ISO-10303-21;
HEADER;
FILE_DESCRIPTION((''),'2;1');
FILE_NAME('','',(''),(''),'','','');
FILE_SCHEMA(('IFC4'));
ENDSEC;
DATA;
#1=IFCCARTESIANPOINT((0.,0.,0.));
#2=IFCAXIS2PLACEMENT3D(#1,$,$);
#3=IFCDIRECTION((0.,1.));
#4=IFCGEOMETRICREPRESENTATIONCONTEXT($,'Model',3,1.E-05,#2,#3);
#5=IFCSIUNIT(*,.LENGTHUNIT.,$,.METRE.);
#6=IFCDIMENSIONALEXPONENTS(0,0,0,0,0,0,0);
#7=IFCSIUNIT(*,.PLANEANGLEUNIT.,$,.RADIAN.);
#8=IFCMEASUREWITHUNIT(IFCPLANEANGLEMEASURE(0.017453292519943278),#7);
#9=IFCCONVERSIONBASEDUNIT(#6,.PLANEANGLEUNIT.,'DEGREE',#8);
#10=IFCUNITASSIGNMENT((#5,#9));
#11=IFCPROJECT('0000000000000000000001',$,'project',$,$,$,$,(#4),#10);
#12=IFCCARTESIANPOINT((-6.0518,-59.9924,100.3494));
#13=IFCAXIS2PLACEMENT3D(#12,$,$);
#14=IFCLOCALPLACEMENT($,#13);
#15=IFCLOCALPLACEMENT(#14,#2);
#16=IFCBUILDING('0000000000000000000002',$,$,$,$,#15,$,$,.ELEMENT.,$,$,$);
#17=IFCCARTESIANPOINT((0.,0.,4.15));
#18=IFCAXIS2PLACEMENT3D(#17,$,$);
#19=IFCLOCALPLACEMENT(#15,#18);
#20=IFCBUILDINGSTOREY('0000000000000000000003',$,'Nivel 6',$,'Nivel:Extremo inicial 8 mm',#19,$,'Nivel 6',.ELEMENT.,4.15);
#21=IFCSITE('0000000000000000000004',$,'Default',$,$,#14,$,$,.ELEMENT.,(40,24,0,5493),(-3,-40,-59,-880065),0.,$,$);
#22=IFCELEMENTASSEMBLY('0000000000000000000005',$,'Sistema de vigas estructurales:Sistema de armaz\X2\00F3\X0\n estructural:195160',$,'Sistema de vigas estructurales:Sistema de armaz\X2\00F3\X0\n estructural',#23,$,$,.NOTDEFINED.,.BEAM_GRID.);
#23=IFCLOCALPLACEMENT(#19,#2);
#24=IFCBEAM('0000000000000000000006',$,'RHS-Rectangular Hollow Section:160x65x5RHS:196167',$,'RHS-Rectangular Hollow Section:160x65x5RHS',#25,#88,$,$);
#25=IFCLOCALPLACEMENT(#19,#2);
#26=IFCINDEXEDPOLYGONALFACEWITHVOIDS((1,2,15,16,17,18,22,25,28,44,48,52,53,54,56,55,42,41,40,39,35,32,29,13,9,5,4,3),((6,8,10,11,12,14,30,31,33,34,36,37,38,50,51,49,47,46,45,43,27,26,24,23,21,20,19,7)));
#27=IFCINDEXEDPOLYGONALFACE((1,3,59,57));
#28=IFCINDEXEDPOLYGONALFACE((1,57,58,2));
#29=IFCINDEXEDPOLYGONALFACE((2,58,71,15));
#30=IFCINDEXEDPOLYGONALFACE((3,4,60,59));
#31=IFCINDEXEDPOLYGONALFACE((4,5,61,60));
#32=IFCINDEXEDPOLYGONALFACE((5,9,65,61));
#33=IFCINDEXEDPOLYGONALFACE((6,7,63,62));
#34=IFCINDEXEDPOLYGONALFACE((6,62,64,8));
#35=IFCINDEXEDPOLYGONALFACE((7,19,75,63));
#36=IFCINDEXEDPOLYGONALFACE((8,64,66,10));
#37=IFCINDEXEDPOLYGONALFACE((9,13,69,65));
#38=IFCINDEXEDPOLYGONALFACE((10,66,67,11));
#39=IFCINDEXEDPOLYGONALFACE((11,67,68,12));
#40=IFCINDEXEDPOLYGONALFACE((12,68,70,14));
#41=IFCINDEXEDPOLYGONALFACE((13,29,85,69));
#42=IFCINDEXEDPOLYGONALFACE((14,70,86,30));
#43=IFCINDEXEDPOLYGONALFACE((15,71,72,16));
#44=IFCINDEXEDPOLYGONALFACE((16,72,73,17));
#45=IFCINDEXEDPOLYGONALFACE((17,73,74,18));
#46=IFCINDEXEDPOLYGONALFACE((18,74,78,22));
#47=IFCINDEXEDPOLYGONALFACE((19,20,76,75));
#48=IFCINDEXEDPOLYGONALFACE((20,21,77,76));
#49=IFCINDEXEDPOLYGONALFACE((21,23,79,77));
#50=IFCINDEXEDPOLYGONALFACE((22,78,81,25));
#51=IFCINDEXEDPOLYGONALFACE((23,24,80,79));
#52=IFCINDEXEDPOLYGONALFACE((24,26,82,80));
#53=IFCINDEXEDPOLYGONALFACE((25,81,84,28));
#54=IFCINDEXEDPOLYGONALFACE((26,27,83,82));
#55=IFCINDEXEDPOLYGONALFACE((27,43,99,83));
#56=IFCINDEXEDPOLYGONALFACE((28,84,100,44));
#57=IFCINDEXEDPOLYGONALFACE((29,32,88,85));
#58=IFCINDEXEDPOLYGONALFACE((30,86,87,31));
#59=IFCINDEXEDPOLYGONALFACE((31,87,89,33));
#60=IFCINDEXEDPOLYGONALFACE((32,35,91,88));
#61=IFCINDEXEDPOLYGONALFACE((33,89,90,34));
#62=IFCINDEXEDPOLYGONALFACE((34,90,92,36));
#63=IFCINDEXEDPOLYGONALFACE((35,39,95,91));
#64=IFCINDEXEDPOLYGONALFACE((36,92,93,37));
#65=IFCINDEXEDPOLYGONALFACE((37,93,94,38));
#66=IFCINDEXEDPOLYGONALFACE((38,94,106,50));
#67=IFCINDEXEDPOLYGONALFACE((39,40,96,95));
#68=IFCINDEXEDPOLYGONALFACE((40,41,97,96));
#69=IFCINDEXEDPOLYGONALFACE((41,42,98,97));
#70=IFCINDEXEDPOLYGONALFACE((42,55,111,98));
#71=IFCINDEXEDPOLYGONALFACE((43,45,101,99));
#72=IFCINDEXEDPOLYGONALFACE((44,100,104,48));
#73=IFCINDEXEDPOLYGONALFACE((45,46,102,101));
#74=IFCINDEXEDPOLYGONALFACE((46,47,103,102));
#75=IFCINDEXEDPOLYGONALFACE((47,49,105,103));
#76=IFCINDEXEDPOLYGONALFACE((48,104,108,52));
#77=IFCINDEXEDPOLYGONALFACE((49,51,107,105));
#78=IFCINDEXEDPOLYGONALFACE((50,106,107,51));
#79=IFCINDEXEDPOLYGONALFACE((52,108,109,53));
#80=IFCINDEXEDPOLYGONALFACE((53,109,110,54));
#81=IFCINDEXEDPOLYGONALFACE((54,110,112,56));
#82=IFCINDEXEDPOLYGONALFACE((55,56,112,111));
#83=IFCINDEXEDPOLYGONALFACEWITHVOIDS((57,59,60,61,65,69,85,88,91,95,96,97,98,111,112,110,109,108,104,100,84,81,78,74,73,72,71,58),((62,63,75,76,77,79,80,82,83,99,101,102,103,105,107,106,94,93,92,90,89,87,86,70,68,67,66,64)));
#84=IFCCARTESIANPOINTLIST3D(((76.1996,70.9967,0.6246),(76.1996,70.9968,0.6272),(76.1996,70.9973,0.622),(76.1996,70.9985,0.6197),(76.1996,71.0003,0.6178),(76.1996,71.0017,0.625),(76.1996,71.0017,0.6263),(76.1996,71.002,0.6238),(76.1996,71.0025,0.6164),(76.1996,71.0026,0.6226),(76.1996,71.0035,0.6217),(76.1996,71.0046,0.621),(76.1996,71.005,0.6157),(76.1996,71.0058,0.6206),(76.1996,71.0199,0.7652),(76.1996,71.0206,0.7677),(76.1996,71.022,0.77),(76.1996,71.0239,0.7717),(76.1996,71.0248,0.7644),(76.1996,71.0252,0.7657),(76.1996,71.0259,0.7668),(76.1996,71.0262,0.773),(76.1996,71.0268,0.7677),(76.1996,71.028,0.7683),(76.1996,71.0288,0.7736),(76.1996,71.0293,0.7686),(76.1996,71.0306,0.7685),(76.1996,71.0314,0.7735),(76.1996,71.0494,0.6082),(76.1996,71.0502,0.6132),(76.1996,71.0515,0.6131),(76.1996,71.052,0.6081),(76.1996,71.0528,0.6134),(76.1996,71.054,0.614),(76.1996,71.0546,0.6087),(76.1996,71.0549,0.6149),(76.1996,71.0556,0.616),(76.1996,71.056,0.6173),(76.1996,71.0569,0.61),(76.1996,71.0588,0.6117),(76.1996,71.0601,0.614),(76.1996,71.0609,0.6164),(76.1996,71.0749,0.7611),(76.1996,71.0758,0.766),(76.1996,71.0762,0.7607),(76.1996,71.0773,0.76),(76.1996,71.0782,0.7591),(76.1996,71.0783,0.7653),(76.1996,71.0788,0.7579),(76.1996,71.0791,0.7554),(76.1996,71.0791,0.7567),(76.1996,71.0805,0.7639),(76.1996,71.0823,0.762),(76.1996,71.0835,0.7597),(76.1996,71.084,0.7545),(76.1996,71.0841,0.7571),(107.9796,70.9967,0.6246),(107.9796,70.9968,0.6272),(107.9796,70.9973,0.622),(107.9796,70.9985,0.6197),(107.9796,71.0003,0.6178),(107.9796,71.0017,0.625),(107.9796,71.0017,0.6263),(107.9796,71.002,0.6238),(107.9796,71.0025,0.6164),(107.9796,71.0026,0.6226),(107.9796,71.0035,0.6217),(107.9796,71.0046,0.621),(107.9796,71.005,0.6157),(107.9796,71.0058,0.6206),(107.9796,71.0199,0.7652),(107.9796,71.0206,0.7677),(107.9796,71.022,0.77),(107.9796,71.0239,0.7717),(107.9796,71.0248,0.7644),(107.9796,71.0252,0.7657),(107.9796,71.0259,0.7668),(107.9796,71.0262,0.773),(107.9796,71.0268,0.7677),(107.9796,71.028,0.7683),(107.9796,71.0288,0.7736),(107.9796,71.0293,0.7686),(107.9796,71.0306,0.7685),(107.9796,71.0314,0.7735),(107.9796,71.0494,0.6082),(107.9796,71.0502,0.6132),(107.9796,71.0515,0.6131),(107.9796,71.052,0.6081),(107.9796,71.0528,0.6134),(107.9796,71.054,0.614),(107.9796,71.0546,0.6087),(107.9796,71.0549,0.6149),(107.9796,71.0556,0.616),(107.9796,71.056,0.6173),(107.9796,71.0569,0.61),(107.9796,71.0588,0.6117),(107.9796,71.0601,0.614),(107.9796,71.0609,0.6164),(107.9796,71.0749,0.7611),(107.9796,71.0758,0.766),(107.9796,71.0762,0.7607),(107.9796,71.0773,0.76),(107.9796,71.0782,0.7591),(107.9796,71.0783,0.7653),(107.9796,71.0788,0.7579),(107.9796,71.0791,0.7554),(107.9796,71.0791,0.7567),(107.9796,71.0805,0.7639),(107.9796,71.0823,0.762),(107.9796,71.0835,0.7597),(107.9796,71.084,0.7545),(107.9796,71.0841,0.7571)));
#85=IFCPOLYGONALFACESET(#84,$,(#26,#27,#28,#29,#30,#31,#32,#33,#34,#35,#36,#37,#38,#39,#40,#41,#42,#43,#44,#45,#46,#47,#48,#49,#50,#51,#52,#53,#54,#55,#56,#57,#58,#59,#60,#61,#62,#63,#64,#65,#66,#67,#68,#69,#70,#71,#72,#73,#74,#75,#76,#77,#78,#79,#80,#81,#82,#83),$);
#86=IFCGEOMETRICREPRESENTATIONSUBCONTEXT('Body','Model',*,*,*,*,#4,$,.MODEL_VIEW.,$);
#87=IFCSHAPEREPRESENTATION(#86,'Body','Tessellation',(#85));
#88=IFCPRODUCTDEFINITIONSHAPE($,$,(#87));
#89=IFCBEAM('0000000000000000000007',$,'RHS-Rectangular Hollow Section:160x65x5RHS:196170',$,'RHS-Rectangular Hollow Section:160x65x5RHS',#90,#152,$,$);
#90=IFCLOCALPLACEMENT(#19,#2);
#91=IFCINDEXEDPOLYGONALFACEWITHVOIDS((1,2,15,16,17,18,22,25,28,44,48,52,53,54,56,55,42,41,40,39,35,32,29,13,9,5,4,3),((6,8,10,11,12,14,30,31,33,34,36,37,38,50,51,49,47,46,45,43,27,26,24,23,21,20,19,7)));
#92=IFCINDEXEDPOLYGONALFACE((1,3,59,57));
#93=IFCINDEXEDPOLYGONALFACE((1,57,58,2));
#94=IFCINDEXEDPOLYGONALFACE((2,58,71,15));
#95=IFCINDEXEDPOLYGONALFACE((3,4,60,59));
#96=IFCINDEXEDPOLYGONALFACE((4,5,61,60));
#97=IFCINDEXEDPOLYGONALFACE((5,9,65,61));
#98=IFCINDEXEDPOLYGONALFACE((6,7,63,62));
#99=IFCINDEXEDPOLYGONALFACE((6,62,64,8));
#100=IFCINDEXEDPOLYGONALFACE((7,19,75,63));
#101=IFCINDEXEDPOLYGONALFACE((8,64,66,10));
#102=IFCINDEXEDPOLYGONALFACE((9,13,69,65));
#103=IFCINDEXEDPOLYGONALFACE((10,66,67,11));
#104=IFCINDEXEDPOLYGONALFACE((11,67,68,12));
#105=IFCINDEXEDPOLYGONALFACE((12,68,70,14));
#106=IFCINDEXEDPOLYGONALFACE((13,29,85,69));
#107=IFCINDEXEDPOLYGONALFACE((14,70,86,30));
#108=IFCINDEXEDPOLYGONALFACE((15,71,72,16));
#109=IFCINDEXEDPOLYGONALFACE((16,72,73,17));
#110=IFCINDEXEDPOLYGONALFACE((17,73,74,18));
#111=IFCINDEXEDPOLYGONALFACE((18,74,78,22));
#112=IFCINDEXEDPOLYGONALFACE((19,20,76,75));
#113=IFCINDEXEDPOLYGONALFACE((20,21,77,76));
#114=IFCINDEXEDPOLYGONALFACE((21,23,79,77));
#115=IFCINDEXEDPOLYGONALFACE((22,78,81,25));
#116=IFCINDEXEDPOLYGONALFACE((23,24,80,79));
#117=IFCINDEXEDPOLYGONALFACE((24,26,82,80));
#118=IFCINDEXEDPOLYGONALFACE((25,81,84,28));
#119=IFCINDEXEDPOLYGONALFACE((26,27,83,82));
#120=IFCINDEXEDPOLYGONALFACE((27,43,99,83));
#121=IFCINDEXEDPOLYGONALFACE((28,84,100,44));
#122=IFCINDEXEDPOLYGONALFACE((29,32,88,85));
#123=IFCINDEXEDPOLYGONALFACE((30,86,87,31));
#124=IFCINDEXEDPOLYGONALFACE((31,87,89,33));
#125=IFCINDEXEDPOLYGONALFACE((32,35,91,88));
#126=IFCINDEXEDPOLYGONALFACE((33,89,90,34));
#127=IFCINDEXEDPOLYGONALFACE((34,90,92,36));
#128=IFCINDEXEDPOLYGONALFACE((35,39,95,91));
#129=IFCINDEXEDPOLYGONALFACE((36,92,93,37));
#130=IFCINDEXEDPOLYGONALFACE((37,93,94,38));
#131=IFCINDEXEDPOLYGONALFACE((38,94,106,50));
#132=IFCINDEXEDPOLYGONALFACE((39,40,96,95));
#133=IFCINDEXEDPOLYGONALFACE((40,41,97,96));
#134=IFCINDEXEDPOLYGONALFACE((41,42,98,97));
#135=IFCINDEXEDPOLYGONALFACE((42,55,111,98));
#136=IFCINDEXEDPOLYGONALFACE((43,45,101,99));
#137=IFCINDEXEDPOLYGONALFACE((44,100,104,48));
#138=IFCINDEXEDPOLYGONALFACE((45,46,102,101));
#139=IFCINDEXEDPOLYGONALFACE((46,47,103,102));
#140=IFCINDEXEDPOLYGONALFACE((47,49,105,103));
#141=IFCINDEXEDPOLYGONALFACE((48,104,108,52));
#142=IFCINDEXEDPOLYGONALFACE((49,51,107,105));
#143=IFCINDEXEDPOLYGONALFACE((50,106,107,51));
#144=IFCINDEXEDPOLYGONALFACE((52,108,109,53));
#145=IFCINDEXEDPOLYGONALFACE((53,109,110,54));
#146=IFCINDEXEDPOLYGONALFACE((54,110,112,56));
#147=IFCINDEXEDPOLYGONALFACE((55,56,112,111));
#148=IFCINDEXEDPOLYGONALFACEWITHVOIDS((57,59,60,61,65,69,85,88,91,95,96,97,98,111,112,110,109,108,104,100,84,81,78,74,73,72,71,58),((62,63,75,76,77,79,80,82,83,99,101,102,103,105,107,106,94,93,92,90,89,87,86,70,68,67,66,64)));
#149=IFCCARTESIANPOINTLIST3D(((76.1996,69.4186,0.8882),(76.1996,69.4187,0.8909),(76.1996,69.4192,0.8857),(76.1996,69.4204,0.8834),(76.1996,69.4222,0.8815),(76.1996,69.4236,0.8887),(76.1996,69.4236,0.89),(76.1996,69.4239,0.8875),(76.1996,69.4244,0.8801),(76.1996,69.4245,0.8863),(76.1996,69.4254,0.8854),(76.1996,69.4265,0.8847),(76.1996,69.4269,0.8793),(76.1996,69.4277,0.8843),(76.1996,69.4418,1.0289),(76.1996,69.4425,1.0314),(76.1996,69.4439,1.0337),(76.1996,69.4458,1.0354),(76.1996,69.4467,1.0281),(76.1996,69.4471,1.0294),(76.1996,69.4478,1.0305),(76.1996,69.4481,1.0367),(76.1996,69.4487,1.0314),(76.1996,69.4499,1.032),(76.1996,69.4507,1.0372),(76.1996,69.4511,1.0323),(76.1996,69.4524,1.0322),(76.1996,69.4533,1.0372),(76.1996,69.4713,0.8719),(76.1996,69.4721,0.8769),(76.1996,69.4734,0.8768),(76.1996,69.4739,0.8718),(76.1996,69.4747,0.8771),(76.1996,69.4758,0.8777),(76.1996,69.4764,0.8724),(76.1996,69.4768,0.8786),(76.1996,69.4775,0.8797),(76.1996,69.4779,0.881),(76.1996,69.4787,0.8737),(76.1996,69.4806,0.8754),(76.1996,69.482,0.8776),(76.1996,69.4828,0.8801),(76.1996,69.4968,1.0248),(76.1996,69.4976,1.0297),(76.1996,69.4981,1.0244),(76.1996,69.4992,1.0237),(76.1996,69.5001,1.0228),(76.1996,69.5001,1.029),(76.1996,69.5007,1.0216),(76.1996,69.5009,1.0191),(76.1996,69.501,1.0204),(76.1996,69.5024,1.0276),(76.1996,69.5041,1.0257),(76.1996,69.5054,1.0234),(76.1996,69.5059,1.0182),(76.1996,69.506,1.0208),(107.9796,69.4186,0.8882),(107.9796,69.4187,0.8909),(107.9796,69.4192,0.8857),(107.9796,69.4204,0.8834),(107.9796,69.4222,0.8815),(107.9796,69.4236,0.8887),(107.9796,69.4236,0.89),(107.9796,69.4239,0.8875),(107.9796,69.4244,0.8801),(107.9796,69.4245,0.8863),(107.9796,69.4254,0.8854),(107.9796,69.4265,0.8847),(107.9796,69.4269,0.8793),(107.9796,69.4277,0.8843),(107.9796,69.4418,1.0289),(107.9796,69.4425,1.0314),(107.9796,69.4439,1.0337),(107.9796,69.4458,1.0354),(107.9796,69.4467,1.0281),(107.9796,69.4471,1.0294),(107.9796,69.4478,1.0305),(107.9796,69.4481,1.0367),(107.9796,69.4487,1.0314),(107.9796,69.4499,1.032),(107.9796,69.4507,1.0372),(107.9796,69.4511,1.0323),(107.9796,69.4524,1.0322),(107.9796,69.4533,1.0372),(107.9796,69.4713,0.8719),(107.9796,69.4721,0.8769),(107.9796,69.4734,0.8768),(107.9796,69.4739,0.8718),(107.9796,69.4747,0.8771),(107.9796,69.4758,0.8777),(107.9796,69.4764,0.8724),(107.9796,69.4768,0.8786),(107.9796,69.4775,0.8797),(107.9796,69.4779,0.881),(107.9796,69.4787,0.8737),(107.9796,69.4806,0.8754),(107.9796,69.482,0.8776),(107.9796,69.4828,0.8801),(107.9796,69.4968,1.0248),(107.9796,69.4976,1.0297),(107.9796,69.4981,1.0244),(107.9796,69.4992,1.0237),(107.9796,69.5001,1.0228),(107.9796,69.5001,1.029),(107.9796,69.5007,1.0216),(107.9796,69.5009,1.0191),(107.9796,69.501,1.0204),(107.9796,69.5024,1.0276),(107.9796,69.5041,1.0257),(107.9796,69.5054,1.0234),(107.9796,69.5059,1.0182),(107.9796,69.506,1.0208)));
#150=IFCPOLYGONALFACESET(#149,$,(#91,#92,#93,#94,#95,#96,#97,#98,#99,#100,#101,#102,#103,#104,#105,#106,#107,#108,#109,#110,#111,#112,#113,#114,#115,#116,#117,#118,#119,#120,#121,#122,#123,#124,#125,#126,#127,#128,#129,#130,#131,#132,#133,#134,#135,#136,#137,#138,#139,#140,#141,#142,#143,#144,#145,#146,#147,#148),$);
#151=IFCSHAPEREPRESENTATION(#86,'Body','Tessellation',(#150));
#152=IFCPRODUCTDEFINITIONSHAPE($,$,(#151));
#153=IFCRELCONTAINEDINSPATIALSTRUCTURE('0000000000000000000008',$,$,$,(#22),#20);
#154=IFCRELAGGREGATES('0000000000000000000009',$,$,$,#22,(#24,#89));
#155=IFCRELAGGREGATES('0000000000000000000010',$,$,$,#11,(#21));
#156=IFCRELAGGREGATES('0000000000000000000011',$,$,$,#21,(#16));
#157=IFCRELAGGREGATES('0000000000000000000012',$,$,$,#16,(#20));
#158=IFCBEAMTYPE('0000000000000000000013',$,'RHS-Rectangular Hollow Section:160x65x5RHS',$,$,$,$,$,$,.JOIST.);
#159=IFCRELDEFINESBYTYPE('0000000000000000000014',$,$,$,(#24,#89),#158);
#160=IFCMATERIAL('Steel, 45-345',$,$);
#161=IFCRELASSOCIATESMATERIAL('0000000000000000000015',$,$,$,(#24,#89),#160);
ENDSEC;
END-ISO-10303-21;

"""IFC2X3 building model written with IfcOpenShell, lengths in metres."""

from ifc_helpers import new_model, entity, si_unit, converted_unit, direction, frame, frame_2d, origin, place, context, subcontext, project, spatial, polyline, circle_curve, parameter, trimmed, segment, composite_curve, outline, extrude, material, type_object, element, aggregate, save


model = new_model("IFC2X3")

# Units and contexts
model_context = context("Model", 3, precision=1e-05, world=origin(), true_north=direction((0.0, 1.0)))
body_context = subcontext(model_context, "Body", "Model", "MODEL_VIEW")
ifc_project = project(units=[si_unit("LENGTHUNIT", "METRE"), converted_unit("PLANEANGLEUNIT", "DEGREE", entity("IfcPlaneAngleMeasure", 0.017453292519943278), si_unit("PLANEANGLEUNIT", "RADIAN"), dimensions=[0, 0, 0, 0, 0, 0, 0])], contexts=[model_context])

# Site, building, storey
site_placement = place(None, frame((-6.0518, -59.9924, 100.3494)))
site = spatial("IfcSite", under=ifc_project, at=site_placement, Name="Default", CompositionType="ELEMENT", RefLatitude=(40, 24, 0, 5493), RefLongitude=(-3, -40, -59, -880065), RefElevation=0.0)
building_placement = place(site_placement, origin())
building = spatial("IfcBuilding", under=site, at=building_placement, CompositionType="ELEMENT")
storey_placement = place(building_placement, frame((0.0, 0.0, 4.15)))
storey = spatial("IfcBuildingStorey", under=building, at=storey_placement, Name="Nivel 6", ObjectType="Nivel:Extremo inicial 8 mm", LongName="Nivel 6", CompositionType="ELEMENT", Elevation=4.15)

# Shared definitions
ifc_material_1 = material(Name="Steel, 45-345")

# Element assembly, beams
assembly_placement = place(storey_placement, origin())
assembly = element("IfcElementAssembly", 1, at=assembly_placement, inside=storey, Name="Sistema de vigas estructurales:Sistema de armazón estructural:195160", ObjectType="Sistema de vigas estructurales:Sistema de armazón estructural", AssemblyPlace="NOTDEFINED", PredefinedType="BEAM_GRID")
beam_type_1 = type_object("IfcBeamType", Name="RHS-Rectangular Hollow Section:160x65x5RHS", PredefinedType="JOIST")
beam_1_placement = place(assembly_placement, frame((107.9796, 71.0008, 0.4541), z_axis=(0.0, 0.0, 1.0), x_axis=(-1.0, 0.0, 0.0)))
beam_1 = element("IfcBeam", 2, at=beam_1_placement, type_object=beam_type_1, material=ifc_material_1, Name="RHS-Rectangular Hollow Section:160x65x5RHS:196167", ObjectType="RHS-Rectangular Hollow Section:160x65x5RHS", context=body_context, shape_type="SweptSolid", body=[
    extrude(outline(composite_curve([segment(trimmed(circle_curve(frame_2d((-0.0225, -0.07), x_axis=(1.0, 0.0)), 0.01), [parameter(180.0)], [parameter(270.0)], True, "PARAMETER"), True, "CONTINUOUS"), segment(polyline([(-0.0225, -0.08), (0.0225, -0.08)]), True, "CONTINUOUS"), segment(trimmed(circle_curve(frame_2d((0.0225, -0.07), x_axis=(1.0, 0.0)), 0.01), [parameter(270.0)], [parameter(0.0)], True, "PARAMETER"), True, "CONTINUOUS"), segment(polyline([(0.0325, -0.07), (0.0325, 0.07)]), True, "CONTINUOUS"), segment(trimmed(circle_curve(frame_2d((0.0225, 0.07), x_axis=(1.0, 0.0)), 0.01), [parameter(360.0)], [parameter(90.0)], True, "PARAMETER"), True, "CONTINUOUS"), segment(polyline([(0.0225, 0.08), (-0.0225, 0.08)]), True, "CONTINUOUS"), segment(trimmed(circle_curve(frame_2d((-0.0225, 0.07), x_axis=(1.0, 0.0)), 0.01), [parameter(90.0)], [parameter(180.0)], True, "PARAMETER"), True, "CONTINUOUS"), segment(polyline([(-0.0325, 0.07), (-0.0325, -0.07)]), True, "CONTINUOUS")], self_intersect=False), holes=[composite_curve([segment(polyline([(0.0225, -0.075), (-0.0225, -0.075)]), True, "CONTINUOUS"), segment(trimmed(circle_curve(frame_2d((-0.0225, -0.07), x_axis=(1.0, 0.0)), 0.005), [parameter(180.0)], [parameter(270.0)], True, "PARAMETER"), False, "CONTINUOUS"), segment(polyline([(-0.0275, -0.07), (-0.0275, 0.07)]), True, "CONTINUOUS"), segment(trimmed(circle_curve(frame_2d((-0.0225, 0.07), x_axis=(1.0, 0.0)), 0.005), [parameter(90.0)], [parameter(180.0)], True, "PARAMETER"), False, "CONTINUOUS"), segment(polyline([(-0.0225, 0.075), (0.0225, 0.075)]), True, "CONTINUOUS"), segment(trimmed(circle_curve(frame_2d((0.0225, 0.07), x_axis=(1.0, 0.0)), 0.005), [parameter(0.0)], [parameter(90.0)], True, "PARAMETER"), False, "CONTINUOUS"), segment(polyline([(0.0275, 0.07), (0.0275, -0.07)]), True, "CONTINUOUS"), segment(trimmed(circle_curve(frame_2d((0.0225, -0.07), x_axis=(1.0, 0.0)), 0.005), [parameter(270.0)], [parameter(0.0)], True, "PARAMETER"), False, "CONTINUOUS")], self_intersect=False)]), frame((0.0, -0.0396, 0.2367), z_axis=(1.0, 0.0, 0.0), x_axis=(0.0, -0.986325, -0.16481)), (0.0, 0.0, 1.0), 31.78),
])
beam_2_placement = place(assembly_placement, frame((107.9796, 69.4227, 0.7178), z_axis=(0.0, 0.0, 1.0), x_axis=(-1.0, 0.0, 0.0)))
beam_2 = element("IfcBeam", 3, at=beam_2_placement, type_object=beam_type_1, material=ifc_material_1, Name="RHS-Rectangular Hollow Section:160x65x5RHS:196170", ObjectType="RHS-Rectangular Hollow Section:160x65x5RHS", context=body_context, shape_type="SweptSolid", body=[
    extrude(outline(composite_curve([segment(trimmed(circle_curve(frame_2d((-0.0225, -0.07), x_axis=(1.0, 0.0)), 0.01), [parameter(180.0)], [parameter(270.0)], True, "PARAMETER"), True, "CONTINUOUS"), segment(polyline([(-0.0225, -0.08), (0.0225, -0.08)]), True, "CONTINUOUS"), segment(trimmed(circle_curve(frame_2d((0.0225, -0.07), x_axis=(1.0, 0.0)), 0.01), [parameter(270.0)], [parameter(0.0)], True, "PARAMETER"), True, "CONTINUOUS"), segment(polyline([(0.0325, -0.07), (0.0325, 0.07)]), True, "CONTINUOUS"), segment(trimmed(circle_curve(frame_2d((0.0225, 0.07), x_axis=(1.0, 0.0)), 0.01), [parameter(360.0)], [parameter(90.0)], True, "PARAMETER"), True, "CONTINUOUS"), segment(polyline([(0.0225, 0.08), (-0.0225, 0.08)]), True, "CONTINUOUS"), segment(trimmed(circle_curve(frame_2d((-0.0225, 0.07), x_axis=(1.0, 0.0)), 0.01), [parameter(90.0)], [parameter(180.0)], True, "PARAMETER"), True, "CONTINUOUS"), segment(polyline([(-0.0325, 0.07), (-0.0325, -0.07)]), True, "CONTINUOUS")], self_intersect=False), holes=[composite_curve([segment(polyline([(0.0225, -0.075), (-0.0225, -0.075)]), True, "CONTINUOUS"), segment(trimmed(circle_curve(frame_2d((-0.0225, -0.07), x_axis=(1.0, 0.0)), 0.005), [parameter(180.0)], [parameter(270.0)], True, "PARAMETER"), False, "CONTINUOUS"), segment(polyline([(-0.0275, -0.07), (-0.0275, 0.07)]), True, "CONTINUOUS"), segment(trimmed(circle_curve(frame_2d((-0.0225, 0.07), x_axis=(1.0, 0.0)), 0.005), [parameter(90.0)], [parameter(180.0)], True, "PARAMETER"), False, "CONTINUOUS"), segment(polyline([(-0.0225, 0.075), (0.0225, 0.075)]), True, "CONTINUOUS"), segment(trimmed(circle_curve(frame_2d((0.0225, 0.07), x_axis=(1.0, 0.0)), 0.005), [parameter(0.0)], [parameter(90.0)], True, "PARAMETER"), False, "CONTINUOUS"), segment(polyline([(0.0275, 0.07), (0.0275, -0.07)]), True, "CONTINUOUS"), segment(trimmed(circle_curve(frame_2d((0.0225, -0.07), x_axis=(1.0, 0.0)), 0.005), [parameter(270.0)], [parameter(0.0)], True, "PARAMETER"), False, "CONTINUOUS")], self_intersect=False)]), frame((0.0, -0.0396, 0.2367), z_axis=(1.0, 0.0, 0.0), x_axis=(0.0, -0.986325, -0.16481)), (0.0, 0.0, 1.0), 31.78),
])
aggregate(assembly, [beam_1, beam_2])

save(model, "model.ifc")
